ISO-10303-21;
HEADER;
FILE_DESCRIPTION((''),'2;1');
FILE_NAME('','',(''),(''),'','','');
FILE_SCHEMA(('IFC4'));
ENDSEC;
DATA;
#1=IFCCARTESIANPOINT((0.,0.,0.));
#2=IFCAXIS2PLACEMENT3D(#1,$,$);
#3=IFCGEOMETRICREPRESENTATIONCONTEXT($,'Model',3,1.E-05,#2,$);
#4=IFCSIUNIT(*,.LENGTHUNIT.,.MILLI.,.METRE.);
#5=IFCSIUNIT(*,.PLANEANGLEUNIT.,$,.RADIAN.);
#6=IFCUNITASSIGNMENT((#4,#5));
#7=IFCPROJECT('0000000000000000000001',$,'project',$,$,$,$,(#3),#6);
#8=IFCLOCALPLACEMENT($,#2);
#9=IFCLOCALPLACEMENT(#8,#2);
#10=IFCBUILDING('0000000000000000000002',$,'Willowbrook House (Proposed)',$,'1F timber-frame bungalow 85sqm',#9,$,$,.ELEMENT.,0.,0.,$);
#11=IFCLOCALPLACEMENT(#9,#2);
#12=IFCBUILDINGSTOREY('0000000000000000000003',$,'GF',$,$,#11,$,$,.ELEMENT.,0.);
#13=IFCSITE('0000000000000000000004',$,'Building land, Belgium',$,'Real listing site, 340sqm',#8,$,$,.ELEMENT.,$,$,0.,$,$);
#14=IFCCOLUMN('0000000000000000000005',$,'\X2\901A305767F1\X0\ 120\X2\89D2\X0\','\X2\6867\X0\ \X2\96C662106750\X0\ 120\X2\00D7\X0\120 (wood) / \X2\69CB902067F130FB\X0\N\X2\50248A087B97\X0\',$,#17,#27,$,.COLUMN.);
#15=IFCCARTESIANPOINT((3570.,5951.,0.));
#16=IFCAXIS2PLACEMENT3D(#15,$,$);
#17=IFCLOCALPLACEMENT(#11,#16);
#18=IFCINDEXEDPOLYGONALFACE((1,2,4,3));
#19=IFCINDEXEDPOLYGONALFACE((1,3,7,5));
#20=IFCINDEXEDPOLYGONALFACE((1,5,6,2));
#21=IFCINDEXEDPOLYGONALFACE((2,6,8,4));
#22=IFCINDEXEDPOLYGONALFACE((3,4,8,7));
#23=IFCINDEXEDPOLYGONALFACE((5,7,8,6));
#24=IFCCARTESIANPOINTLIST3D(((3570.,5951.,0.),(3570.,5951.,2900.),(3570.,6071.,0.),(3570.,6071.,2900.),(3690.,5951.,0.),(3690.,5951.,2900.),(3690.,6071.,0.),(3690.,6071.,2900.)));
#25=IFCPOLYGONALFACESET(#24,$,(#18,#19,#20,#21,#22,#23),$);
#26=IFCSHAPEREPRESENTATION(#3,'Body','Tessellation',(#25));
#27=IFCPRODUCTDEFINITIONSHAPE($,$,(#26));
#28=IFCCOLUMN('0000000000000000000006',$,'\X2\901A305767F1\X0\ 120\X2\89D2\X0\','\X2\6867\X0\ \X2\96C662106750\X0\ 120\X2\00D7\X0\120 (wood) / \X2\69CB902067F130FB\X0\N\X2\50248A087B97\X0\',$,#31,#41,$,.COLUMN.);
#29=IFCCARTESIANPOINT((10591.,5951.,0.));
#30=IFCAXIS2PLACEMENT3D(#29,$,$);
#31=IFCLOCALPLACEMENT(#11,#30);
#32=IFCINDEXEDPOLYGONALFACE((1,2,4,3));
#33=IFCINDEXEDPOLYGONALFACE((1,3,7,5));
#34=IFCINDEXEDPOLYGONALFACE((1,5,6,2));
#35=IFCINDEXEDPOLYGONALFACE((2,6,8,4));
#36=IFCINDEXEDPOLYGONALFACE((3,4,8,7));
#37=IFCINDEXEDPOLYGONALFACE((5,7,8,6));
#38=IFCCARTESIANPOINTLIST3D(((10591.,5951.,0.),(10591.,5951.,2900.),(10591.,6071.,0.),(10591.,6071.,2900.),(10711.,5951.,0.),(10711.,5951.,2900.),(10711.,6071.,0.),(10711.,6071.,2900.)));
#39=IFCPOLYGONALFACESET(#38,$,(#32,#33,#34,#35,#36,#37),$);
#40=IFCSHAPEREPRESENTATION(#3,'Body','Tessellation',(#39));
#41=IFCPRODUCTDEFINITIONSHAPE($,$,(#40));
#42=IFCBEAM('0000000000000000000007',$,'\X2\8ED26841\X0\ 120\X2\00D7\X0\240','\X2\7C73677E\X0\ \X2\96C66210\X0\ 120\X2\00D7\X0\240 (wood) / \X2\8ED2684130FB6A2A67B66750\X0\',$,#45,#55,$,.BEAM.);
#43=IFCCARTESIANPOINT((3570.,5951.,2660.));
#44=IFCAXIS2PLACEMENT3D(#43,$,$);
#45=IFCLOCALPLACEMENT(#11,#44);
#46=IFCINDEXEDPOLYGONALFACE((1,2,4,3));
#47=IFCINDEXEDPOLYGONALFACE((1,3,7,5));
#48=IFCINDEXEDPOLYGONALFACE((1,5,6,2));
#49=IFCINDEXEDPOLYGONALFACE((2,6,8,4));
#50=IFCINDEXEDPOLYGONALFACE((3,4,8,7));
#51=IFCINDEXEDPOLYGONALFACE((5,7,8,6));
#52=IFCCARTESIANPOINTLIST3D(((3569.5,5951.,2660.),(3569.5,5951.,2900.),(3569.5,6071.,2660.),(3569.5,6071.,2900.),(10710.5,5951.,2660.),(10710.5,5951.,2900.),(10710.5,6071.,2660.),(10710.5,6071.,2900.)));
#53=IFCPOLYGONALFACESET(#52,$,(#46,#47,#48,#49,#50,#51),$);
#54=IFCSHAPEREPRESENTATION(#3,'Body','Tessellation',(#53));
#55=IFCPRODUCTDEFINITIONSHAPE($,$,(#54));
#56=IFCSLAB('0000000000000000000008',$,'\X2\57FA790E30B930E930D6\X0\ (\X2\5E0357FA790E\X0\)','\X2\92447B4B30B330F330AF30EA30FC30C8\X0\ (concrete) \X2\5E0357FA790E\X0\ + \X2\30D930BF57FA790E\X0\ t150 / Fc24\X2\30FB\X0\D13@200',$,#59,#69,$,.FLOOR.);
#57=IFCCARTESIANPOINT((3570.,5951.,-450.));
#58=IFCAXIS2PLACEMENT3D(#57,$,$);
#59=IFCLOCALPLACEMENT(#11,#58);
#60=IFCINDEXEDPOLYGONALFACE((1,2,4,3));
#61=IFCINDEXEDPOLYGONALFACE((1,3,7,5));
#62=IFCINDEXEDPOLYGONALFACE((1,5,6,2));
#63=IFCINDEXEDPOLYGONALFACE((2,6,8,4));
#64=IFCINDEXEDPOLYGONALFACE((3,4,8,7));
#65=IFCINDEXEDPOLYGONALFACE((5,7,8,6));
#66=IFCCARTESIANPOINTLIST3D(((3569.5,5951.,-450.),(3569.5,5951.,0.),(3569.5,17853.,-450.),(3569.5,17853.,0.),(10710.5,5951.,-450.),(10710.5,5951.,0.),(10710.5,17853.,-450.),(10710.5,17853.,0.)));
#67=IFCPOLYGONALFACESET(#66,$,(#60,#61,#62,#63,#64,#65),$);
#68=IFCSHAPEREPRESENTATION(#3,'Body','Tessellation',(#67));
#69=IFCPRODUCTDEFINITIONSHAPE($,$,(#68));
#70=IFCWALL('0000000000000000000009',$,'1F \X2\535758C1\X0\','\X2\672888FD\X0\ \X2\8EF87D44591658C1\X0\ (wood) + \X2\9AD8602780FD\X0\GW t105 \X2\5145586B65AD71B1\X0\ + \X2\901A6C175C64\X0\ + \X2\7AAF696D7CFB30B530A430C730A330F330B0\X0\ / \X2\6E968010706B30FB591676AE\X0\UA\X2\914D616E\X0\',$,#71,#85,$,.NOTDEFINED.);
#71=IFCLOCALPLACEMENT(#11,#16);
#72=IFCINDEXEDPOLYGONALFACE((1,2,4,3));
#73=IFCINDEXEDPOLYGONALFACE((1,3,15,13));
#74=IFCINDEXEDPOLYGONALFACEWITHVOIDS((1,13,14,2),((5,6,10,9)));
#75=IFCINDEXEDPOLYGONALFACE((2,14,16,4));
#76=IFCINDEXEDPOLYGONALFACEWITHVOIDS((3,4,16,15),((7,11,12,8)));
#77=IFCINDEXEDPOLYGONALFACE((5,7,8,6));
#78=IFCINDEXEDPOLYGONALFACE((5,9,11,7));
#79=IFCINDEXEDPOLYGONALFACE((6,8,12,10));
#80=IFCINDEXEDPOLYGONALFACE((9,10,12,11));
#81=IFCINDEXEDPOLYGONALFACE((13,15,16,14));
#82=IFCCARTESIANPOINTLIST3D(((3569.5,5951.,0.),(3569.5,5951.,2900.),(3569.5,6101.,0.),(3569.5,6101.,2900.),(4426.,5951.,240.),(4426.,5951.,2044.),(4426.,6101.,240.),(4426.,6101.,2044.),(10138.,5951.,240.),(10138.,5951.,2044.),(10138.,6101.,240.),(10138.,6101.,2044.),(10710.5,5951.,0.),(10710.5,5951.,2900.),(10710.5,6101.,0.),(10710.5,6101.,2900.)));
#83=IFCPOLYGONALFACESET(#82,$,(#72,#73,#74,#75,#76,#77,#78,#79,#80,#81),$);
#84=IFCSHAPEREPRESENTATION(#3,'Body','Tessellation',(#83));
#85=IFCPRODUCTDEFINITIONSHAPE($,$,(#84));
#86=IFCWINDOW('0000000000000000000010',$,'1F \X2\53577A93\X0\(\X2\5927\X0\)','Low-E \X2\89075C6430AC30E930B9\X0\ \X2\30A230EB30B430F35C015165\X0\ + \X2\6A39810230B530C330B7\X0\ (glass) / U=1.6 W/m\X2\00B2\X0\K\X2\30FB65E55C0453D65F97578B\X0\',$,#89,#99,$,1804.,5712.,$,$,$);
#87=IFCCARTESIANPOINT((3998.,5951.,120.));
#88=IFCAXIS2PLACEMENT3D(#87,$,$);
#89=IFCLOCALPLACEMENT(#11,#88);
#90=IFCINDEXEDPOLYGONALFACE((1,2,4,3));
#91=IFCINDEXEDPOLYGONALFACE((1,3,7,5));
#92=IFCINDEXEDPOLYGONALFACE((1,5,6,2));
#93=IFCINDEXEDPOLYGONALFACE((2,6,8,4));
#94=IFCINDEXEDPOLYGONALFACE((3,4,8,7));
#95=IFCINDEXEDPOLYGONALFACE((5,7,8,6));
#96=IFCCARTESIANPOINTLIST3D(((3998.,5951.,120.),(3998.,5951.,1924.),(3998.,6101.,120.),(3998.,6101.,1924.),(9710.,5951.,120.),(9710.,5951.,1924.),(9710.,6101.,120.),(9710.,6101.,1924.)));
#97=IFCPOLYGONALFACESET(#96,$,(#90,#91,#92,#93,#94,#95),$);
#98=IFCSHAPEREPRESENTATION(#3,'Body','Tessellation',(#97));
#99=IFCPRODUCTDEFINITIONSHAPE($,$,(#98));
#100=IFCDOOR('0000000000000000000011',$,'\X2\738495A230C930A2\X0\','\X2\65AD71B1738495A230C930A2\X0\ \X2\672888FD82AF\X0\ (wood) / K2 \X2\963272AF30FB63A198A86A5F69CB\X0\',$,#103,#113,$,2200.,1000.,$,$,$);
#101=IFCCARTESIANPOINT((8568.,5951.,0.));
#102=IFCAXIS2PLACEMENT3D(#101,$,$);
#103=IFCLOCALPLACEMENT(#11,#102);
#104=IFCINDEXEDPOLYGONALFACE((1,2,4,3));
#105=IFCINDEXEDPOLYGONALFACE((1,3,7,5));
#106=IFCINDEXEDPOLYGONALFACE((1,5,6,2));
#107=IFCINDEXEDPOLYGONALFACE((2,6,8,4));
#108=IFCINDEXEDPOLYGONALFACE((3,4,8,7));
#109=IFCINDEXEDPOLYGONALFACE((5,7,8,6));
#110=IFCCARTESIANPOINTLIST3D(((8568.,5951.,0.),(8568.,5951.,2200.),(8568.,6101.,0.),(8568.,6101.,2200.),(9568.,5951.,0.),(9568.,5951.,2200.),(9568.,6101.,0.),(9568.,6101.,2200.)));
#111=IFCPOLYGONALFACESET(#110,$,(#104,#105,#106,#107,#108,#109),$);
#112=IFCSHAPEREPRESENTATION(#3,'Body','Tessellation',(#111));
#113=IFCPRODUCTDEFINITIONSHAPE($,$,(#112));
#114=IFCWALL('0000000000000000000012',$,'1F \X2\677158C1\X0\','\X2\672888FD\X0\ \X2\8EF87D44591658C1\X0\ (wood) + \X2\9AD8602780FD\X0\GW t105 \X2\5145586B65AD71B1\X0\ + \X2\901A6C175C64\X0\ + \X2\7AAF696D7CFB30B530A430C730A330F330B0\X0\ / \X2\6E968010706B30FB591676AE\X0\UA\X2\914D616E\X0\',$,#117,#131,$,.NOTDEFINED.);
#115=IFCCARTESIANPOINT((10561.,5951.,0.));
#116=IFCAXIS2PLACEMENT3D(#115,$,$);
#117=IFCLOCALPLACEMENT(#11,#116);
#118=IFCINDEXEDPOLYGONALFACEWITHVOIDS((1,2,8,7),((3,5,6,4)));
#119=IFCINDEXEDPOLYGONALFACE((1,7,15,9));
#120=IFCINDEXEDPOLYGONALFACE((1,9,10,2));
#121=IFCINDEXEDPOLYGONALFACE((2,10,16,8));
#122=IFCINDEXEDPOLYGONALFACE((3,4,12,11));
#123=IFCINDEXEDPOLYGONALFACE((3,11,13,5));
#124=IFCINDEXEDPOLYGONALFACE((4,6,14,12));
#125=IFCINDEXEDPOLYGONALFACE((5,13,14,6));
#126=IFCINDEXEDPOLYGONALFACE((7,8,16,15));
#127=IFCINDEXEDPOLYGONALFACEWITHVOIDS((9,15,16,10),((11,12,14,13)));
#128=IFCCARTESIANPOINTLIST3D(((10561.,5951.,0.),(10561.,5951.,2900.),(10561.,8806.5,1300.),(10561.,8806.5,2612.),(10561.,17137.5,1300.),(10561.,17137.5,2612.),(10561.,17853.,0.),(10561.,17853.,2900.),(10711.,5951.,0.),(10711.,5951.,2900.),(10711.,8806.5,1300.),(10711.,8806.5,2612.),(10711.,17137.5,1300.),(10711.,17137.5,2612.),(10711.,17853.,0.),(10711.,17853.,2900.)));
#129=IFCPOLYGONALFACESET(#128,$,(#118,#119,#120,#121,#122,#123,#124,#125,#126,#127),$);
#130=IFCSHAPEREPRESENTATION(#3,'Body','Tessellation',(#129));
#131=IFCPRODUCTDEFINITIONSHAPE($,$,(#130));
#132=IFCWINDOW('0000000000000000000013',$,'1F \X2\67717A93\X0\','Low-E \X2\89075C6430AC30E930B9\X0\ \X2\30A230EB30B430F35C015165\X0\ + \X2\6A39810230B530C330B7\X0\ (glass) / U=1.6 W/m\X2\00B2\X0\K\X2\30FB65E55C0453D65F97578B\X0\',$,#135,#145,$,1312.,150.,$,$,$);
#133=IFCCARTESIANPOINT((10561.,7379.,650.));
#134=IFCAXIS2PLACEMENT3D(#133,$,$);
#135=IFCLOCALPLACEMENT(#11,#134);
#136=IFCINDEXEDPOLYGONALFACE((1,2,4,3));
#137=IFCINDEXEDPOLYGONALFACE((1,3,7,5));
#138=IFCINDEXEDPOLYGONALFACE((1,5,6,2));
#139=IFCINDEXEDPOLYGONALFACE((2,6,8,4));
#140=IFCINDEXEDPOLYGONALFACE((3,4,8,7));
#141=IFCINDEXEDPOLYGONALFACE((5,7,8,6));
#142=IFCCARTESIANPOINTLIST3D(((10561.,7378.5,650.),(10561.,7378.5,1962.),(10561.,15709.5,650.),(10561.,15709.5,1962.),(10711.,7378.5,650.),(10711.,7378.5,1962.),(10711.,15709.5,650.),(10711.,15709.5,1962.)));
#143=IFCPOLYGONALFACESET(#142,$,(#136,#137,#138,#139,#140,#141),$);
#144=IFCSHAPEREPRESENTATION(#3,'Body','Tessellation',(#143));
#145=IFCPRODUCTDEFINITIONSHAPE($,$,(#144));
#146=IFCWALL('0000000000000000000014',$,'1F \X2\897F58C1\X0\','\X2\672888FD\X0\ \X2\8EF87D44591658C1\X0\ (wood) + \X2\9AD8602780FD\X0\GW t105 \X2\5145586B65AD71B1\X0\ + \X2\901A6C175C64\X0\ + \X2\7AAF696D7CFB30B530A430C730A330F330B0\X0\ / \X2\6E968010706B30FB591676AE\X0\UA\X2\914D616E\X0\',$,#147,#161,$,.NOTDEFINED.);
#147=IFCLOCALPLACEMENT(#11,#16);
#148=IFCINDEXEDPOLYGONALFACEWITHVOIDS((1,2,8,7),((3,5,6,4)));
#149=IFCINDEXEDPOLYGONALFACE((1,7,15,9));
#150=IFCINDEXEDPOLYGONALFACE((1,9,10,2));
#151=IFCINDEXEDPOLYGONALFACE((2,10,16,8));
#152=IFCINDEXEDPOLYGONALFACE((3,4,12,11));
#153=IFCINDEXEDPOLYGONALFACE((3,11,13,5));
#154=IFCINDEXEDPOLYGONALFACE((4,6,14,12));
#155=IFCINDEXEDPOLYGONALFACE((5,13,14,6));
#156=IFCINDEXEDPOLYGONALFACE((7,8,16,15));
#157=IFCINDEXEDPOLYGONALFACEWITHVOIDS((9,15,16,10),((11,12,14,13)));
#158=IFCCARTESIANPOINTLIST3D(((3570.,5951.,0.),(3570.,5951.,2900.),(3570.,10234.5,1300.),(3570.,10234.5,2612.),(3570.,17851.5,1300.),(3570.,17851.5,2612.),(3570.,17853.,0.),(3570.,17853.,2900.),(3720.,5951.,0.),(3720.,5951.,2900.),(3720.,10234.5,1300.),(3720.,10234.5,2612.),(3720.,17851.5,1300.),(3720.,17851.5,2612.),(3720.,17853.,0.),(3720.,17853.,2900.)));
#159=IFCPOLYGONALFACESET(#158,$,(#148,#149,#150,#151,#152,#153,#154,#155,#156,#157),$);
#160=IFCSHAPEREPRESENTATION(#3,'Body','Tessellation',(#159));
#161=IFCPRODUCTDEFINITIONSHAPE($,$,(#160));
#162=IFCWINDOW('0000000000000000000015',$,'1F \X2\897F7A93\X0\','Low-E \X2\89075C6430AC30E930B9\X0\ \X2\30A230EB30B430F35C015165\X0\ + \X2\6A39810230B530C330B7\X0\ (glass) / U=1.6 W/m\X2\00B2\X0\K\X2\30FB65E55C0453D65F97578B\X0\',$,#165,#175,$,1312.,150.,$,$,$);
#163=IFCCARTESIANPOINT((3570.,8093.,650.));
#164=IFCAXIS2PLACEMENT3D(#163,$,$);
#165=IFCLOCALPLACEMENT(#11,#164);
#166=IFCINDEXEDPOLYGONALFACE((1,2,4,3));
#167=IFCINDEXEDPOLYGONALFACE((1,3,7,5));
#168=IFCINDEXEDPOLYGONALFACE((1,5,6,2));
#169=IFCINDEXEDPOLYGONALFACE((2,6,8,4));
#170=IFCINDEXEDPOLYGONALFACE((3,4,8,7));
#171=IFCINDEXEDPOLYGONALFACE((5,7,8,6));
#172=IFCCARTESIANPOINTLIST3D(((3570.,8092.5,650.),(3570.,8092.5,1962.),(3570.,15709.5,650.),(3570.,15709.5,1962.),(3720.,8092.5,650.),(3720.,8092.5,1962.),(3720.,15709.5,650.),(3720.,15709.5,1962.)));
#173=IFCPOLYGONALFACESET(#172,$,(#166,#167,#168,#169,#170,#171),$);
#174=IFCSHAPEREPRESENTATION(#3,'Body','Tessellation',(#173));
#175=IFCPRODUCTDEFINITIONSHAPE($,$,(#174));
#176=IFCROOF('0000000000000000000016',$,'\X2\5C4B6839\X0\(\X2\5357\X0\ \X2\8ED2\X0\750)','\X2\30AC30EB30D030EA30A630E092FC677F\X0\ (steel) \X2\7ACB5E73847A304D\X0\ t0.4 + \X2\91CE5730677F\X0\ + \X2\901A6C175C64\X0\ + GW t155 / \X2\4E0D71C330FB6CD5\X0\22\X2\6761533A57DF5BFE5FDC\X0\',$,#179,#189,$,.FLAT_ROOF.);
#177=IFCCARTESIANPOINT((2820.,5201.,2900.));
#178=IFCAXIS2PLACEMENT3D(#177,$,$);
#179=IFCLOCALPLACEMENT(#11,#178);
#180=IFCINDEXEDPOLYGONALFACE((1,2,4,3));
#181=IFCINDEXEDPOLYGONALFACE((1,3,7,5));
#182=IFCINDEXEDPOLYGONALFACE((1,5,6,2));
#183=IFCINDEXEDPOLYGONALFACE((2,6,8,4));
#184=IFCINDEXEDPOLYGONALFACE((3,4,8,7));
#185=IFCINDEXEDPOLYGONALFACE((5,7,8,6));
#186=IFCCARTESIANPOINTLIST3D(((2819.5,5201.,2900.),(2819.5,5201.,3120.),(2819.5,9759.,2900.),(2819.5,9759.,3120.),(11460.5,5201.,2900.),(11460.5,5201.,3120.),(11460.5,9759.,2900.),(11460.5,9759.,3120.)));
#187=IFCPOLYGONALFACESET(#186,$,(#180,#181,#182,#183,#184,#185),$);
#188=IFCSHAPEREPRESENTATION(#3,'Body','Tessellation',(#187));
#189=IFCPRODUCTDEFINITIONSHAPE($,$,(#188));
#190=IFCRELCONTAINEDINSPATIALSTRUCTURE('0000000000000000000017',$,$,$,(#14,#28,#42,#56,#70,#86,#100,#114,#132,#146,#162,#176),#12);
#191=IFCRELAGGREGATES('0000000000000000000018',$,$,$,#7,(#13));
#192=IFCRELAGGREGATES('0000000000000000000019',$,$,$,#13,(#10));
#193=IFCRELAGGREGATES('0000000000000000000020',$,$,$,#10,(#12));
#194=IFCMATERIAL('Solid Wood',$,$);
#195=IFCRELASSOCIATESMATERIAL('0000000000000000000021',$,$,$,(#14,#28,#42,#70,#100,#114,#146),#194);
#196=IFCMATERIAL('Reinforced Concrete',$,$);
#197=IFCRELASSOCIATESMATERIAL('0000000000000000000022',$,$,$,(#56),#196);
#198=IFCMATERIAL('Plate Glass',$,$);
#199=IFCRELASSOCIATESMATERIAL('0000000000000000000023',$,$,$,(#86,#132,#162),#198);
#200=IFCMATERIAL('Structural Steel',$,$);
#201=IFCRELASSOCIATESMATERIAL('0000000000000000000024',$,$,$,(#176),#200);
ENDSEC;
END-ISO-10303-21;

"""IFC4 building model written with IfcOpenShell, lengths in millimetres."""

from ifc_helpers import new_model, si_unit, frame, frame_2d, origin, place, context, project, spatial, rectangle, extrude, material, element, fill, save


model = new_model("IFC4")

# Units and contexts
model_context = context("Model", 3, precision=1e-05, world=origin())
ifc_project = project(units=[si_unit("LENGTHUNIT", "METRE", prefix="MILLI"), si_unit("PLANEANGLEUNIT", "RADIAN")], contexts=[model_context])

# Site, building, storey
site_placement = place(None, origin())
site = spatial("IfcSite", under=ifc_project, at=site_placement, Name="Building land, Belgium", ObjectType="Real listing site, 340sqm", CompositionType="ELEMENT", RefElevation=0.0)
building_placement = place(site_placement, origin())
building = spatial("IfcBuilding", under=site, at=building_placement, Name="Willowbrook House (Proposed)", ObjectType="1F timber-frame bungalow 85sqm", CompositionType="ELEMENT", ElevationOfRefHeight=0.0, ElevationOfTerrain=0.0)
storey_placement = place(building_placement, origin())
storey = spatial("IfcBuildingStorey", under=building, at=storey_placement, Name="GF", CompositionType="ELEMENT", Elevation=0.0)

# Columns
ifc_material_1 = material(Name="Solid Wood")
column_1_placement = place(storey_placement, frame((3570.0, 5951.0, 0.0)))
element("IfcColumn", 1, at=column_1_placement, inside=storey, material=ifc_material_1, Name="通し柱 120角", Description="桧 集成材 120×120 (wood) / 構造柱・N値計算", PredefinedType="COLUMN", context=model_context, shape_type="SweptSolid", body=[
    extrude(rectangle(XDim=120.0, YDim=120.0, at=frame_2d((60.0, 60.0))), frame((3570.0, 5951.0, 0.0)), (0.0, 0.0, 1.0), 2900.0),
])
column_2_placement = place(storey_placement, frame((10591.0, 5951.0, 0.0)))
element("IfcColumn", 2, at=column_2_placement, inside=storey, material=ifc_material_1, Name="通し柱 120角", Description="桧 集成材 120×120 (wood) / 構造柱・N値計算", PredefinedType="COLUMN", context=model_context, shape_type="SweptSolid", body=[
    extrude(rectangle(XDim=120.0, YDim=120.0, at=frame_2d((60.0, 60.0))), frame((10591.0, 5951.0, 0.0)), (0.0, 0.0, 1.0), 2900.0),
])

# Beam
beam_1_placement = place(storey_placement, frame((3570.0, 5951.0, 2660.0)))
element("IfcBeam", 3, at=beam_1_placement, inside=storey, material=ifc_material_1, Name="軒桁 120×240", Description="米松 集成 120×240 (wood) / 軒桁・横架材", PredefinedType="BEAM", context=model_context, shape_type="SweptSolid", body=[
    extrude(rectangle(XDim=7141.0, YDim=120.0, at=frame_2d((3570.0, 60.0))), frame((3570.0, 5951.0, 2660.0)), (0.0, 0.0, 1.0), 240.0),
])

# Slab
ifc_material_2 = material(Name="Reinforced Concrete")
slab_1_placement = place(storey_placement, frame((3570.0, 5951.0, -450.0)))
element("IfcSlab", 4, at=slab_1_placement, inside=storey, material=ifc_material_2, Name="基礎スラブ (布基礎)", Description="鉄筋コンクリート (concrete) 布基礎 + ベタ基礎 t150 / Fc24・D13@200", PredefinedType="FLOOR", context=model_context, shape_type="SweptSolid", body=[
    extrude(rectangle(XDim=7141.0, YDim=11902.0, at=frame_2d((3570.0, 5951.0))), frame((3570.0, 5951.0, -450.0)), (0.0, 0.0, 1.0), 450.0),
])

# Wall, openings, window, door
wall_1_placement = place(storey_placement, frame((3570.0, 5951.0, 0.0)))
wall_1 = element("IfcWall", 5, at=wall_1_placement, inside=storey, material=ifc_material_1, Name="1F 南壁", Description="木製 軸組外壁 (wood) + 高性能GW t105 充填断熱 + 通気層 + 窯業系サイディング / 準耐火・外皮UA配慮", PredefinedType="NOTDEFINED", context=model_context, shape_type="SweptSolid", body=[
    extrude(rectangle(XDim=7141.0, YDim=150.0, at=frame_2d((3570.0, 75.0))), frame((3570.0, 5951.0, 0.0)), (0.0, 0.0, 1.0), 2900.0),
])
opening_1_placement = place(storey_placement, frame((3998.0, 5951.0, 120.0)))
opening_1 = element("IfcOpeningElement", 6, at=opening_1_placement, cuts=wall_1, PredefinedType="NOTDEFINED", context=model_context, shape_type="SweptSolid", body=[
    extrude(rectangle(XDim=5712.0, YDim=150.0, at=frame_2d((2856.0, 75.0))), frame((3998.0, 5951.0, 120.0)), (0.0, 0.0, 1.0), 1804.0),
])
opening_2_placement = place(storey_placement, frame((8568.0, 5951.0, 0.0)))
opening_2 = element("IfcOpeningElement", 7, at=opening_2_placement, cuts=wall_1, PredefinedType="NOTDEFINED", context=model_context, shape_type="SweptSolid", body=[
    extrude(rectangle(XDim=1000.0, YDim=150.0, at=frame_2d((500.0, 75.0))), frame((8568.0, 5951.0, 0.0)), (0.0, 0.0, 1.0), 2200.0),
])
ifc_material_3 = material(Name="Plate Glass")
window_1_placement = place(storey_placement, frame((3998.0, 5951.0, 120.0)))
window_1 = element("IfcWindow", 8, at=window_1_placement, inside=storey, material=ifc_material_3, Name="1F 南窓(大)", Description="Low-E 複層ガラス アルゴン封入 + 樹脂サッシ (glass) / U=1.6 W/m²K・日射取得型", OverallHeight=1804.0, OverallWidth=5712.0, context=model_context, shape_type="SweptSolid", body=[
    extrude(rectangle(XDim=5712.0, YDim=150.0, at=frame_2d((2856.0, 75.0))), frame((3998.0, 5951.0, 120.0)), (0.0, 0.0, 1.0), 1804.0),
])
fill(opening_1, window_1)
door_placement = place(storey_placement, frame((8568.0, 5951.0, 0.0)))
door = element("IfcDoor", 9, at=door_placement, inside=storey, material=ifc_material_1, Name="玄関ドア", Description="断熱玄関ドア 木製芯 (wood) / K2 防犯・採風機構", OverallHeight=2200.0, OverallWidth=1000.0, context=model_context, shape_type="SweptSolid", body=[
    extrude(rectangle(XDim=1000.0, YDim=150.0, at=frame_2d((500.0, 75.0))), frame((8568.0, 5951.0, 0.0)), (0.0, 0.0, 1.0), 2200.0),
])
fill(opening_2, door)

# Walls, openings, windows
wall_2_placement = place(storey_placement, frame((10561.0, 5951.0, 0.0)))
wall_2 = element("IfcWall", 10, at=wall_2_placement, inside=storey, material=ifc_material_1, Name="1F 東壁", Description="木製 軸組外壁 (wood) + 高性能GW t105 充填断熱 + 通気層 + 窯業系サイディング / 準耐火・外皮UA配慮", PredefinedType="NOTDEFINED", context=model_context, shape_type="SweptSolid", body=[
    extrude(rectangle(XDim=150.0, YDim=11902.0, at=frame_2d((75.0, 5951.0))), frame((10561.0, 5951.0, 0.0)), (0.0, 0.0, 1.0), 2900.0),
])
opening_3_placement = place(storey_placement, frame((10561.0, 7379.0, 650.0)))
opening_3 = element("IfcOpeningElement", 11, at=opening_3_placement, cuts=wall_2, PredefinedType="NOTDEFINED", context=model_context, shape_type="SweptSolid", body=[
    extrude(rectangle(XDim=150.0, YDim=8331.0, at=frame_2d((75.0, 4165.0))), frame((10561.0, 7379.0, 650.0)), (0.0, 0.0, 1.0), 1312.0),
])
window_2_placement = place(storey_placement, frame((10561.0, 7379.0, 650.0)))
window_2 = element("IfcWindow", 12, at=window_2_placement, inside=storey, material=ifc_material_3, Name="1F 東窓", Description="Low-E 複層ガラス アルゴン封入 + 樹脂サッシ (glass) / U=1.6 W/m²K・日射取得型", OverallHeight=1312.0, OverallWidth=150.0, context=model_context, shape_type="SweptSolid", body=[
    extrude(rectangle(XDim=150.0, YDim=8331.0, at=frame_2d((75.0, 4165.0))), frame((10561.0, 7379.0, 650.0)), (0.0, 0.0, 1.0), 1312.0),
])
fill(opening_3, window_2)
wall_3_placement = place(storey_placement, frame((3570.0, 5951.0, 0.0)))
wall_3 = element("IfcWall", 13, at=wall_3_placement, inside=storey, material=ifc_material_1, Name="1F 西壁", Description="木製 軸組外壁 (wood) + 高性能GW t105 充填断熱 + 通気層 + 窯業系サイディング / 準耐火・外皮UA配慮", PredefinedType="NOTDEFINED", context=model_context, shape_type="SweptSolid", body=[
    extrude(rectangle(XDim=150.0, YDim=11902.0, at=frame_2d((75.0, 5951.0))), frame((3570.0, 5951.0, 0.0)), (0.0, 0.0, 1.0), 2900.0),
])
opening_4_placement = place(storey_placement, frame((3570.0, 8093.0, 650.0)))
opening_4 = element("IfcOpeningElement", 14, at=opening_4_placement, cuts=wall_3, PredefinedType="NOTDEFINED", context=model_context, shape_type="SweptSolid", body=[
    extrude(rectangle(XDim=150.0, YDim=7617.0, at=frame_2d((75.0, 3808.0))), frame((3570.0, 8093.0, 650.0)), (0.0, 0.0, 1.0), 1312.0),
])
window_3_placement = place(storey_placement, frame((3570.0, 8093.0, 650.0)))
window_3 = element("IfcWindow", 15, at=window_3_placement, inside=storey, material=ifc_material_3, Name="1F 西窓", Description="Low-E 複層ガラス アルゴン封入 + 樹脂サッシ (glass) / U=1.6 W/m²K・日射取得型", OverallHeight=1312.0, OverallWidth=150.0, context=model_context, shape_type="SweptSolid", body=[
    extrude(rectangle(XDim=150.0, YDim=7617.0, at=frame_2d((75.0, 3808.0))), frame((3570.0, 8093.0, 650.0)), (0.0, 0.0, 1.0), 1312.0),
])
fill(opening_4, window_3)

# Roof
ifc_material_4 = material(Name="Structural Steel")
roof_placement = place(storey_placement, frame((2820.0, 5201.0, 2900.0)))
element("IfcRoof", 16, at=roof_placement, inside=storey, material=ifc_material_4, Name="屋根(南 軒750)", Description="ガルバリウム鋼板 (steel) 立平葺き t0.4 + 野地板 + 通気層 + GW t155 / 不燃・法22条区域対応", PredefinedType="FLAT_ROOF", context=model_context, shape_type="SweptSolid", body=[
    extrude(rectangle(XDim=8641.0, YDim=4558.0, at=frame_2d((4320.0, 2279.0))), frame((2820.0, 5201.0, 2900.0)), (0.0, 0.0, 1.0), 220.0),
])

save(model, "model.ifc")
